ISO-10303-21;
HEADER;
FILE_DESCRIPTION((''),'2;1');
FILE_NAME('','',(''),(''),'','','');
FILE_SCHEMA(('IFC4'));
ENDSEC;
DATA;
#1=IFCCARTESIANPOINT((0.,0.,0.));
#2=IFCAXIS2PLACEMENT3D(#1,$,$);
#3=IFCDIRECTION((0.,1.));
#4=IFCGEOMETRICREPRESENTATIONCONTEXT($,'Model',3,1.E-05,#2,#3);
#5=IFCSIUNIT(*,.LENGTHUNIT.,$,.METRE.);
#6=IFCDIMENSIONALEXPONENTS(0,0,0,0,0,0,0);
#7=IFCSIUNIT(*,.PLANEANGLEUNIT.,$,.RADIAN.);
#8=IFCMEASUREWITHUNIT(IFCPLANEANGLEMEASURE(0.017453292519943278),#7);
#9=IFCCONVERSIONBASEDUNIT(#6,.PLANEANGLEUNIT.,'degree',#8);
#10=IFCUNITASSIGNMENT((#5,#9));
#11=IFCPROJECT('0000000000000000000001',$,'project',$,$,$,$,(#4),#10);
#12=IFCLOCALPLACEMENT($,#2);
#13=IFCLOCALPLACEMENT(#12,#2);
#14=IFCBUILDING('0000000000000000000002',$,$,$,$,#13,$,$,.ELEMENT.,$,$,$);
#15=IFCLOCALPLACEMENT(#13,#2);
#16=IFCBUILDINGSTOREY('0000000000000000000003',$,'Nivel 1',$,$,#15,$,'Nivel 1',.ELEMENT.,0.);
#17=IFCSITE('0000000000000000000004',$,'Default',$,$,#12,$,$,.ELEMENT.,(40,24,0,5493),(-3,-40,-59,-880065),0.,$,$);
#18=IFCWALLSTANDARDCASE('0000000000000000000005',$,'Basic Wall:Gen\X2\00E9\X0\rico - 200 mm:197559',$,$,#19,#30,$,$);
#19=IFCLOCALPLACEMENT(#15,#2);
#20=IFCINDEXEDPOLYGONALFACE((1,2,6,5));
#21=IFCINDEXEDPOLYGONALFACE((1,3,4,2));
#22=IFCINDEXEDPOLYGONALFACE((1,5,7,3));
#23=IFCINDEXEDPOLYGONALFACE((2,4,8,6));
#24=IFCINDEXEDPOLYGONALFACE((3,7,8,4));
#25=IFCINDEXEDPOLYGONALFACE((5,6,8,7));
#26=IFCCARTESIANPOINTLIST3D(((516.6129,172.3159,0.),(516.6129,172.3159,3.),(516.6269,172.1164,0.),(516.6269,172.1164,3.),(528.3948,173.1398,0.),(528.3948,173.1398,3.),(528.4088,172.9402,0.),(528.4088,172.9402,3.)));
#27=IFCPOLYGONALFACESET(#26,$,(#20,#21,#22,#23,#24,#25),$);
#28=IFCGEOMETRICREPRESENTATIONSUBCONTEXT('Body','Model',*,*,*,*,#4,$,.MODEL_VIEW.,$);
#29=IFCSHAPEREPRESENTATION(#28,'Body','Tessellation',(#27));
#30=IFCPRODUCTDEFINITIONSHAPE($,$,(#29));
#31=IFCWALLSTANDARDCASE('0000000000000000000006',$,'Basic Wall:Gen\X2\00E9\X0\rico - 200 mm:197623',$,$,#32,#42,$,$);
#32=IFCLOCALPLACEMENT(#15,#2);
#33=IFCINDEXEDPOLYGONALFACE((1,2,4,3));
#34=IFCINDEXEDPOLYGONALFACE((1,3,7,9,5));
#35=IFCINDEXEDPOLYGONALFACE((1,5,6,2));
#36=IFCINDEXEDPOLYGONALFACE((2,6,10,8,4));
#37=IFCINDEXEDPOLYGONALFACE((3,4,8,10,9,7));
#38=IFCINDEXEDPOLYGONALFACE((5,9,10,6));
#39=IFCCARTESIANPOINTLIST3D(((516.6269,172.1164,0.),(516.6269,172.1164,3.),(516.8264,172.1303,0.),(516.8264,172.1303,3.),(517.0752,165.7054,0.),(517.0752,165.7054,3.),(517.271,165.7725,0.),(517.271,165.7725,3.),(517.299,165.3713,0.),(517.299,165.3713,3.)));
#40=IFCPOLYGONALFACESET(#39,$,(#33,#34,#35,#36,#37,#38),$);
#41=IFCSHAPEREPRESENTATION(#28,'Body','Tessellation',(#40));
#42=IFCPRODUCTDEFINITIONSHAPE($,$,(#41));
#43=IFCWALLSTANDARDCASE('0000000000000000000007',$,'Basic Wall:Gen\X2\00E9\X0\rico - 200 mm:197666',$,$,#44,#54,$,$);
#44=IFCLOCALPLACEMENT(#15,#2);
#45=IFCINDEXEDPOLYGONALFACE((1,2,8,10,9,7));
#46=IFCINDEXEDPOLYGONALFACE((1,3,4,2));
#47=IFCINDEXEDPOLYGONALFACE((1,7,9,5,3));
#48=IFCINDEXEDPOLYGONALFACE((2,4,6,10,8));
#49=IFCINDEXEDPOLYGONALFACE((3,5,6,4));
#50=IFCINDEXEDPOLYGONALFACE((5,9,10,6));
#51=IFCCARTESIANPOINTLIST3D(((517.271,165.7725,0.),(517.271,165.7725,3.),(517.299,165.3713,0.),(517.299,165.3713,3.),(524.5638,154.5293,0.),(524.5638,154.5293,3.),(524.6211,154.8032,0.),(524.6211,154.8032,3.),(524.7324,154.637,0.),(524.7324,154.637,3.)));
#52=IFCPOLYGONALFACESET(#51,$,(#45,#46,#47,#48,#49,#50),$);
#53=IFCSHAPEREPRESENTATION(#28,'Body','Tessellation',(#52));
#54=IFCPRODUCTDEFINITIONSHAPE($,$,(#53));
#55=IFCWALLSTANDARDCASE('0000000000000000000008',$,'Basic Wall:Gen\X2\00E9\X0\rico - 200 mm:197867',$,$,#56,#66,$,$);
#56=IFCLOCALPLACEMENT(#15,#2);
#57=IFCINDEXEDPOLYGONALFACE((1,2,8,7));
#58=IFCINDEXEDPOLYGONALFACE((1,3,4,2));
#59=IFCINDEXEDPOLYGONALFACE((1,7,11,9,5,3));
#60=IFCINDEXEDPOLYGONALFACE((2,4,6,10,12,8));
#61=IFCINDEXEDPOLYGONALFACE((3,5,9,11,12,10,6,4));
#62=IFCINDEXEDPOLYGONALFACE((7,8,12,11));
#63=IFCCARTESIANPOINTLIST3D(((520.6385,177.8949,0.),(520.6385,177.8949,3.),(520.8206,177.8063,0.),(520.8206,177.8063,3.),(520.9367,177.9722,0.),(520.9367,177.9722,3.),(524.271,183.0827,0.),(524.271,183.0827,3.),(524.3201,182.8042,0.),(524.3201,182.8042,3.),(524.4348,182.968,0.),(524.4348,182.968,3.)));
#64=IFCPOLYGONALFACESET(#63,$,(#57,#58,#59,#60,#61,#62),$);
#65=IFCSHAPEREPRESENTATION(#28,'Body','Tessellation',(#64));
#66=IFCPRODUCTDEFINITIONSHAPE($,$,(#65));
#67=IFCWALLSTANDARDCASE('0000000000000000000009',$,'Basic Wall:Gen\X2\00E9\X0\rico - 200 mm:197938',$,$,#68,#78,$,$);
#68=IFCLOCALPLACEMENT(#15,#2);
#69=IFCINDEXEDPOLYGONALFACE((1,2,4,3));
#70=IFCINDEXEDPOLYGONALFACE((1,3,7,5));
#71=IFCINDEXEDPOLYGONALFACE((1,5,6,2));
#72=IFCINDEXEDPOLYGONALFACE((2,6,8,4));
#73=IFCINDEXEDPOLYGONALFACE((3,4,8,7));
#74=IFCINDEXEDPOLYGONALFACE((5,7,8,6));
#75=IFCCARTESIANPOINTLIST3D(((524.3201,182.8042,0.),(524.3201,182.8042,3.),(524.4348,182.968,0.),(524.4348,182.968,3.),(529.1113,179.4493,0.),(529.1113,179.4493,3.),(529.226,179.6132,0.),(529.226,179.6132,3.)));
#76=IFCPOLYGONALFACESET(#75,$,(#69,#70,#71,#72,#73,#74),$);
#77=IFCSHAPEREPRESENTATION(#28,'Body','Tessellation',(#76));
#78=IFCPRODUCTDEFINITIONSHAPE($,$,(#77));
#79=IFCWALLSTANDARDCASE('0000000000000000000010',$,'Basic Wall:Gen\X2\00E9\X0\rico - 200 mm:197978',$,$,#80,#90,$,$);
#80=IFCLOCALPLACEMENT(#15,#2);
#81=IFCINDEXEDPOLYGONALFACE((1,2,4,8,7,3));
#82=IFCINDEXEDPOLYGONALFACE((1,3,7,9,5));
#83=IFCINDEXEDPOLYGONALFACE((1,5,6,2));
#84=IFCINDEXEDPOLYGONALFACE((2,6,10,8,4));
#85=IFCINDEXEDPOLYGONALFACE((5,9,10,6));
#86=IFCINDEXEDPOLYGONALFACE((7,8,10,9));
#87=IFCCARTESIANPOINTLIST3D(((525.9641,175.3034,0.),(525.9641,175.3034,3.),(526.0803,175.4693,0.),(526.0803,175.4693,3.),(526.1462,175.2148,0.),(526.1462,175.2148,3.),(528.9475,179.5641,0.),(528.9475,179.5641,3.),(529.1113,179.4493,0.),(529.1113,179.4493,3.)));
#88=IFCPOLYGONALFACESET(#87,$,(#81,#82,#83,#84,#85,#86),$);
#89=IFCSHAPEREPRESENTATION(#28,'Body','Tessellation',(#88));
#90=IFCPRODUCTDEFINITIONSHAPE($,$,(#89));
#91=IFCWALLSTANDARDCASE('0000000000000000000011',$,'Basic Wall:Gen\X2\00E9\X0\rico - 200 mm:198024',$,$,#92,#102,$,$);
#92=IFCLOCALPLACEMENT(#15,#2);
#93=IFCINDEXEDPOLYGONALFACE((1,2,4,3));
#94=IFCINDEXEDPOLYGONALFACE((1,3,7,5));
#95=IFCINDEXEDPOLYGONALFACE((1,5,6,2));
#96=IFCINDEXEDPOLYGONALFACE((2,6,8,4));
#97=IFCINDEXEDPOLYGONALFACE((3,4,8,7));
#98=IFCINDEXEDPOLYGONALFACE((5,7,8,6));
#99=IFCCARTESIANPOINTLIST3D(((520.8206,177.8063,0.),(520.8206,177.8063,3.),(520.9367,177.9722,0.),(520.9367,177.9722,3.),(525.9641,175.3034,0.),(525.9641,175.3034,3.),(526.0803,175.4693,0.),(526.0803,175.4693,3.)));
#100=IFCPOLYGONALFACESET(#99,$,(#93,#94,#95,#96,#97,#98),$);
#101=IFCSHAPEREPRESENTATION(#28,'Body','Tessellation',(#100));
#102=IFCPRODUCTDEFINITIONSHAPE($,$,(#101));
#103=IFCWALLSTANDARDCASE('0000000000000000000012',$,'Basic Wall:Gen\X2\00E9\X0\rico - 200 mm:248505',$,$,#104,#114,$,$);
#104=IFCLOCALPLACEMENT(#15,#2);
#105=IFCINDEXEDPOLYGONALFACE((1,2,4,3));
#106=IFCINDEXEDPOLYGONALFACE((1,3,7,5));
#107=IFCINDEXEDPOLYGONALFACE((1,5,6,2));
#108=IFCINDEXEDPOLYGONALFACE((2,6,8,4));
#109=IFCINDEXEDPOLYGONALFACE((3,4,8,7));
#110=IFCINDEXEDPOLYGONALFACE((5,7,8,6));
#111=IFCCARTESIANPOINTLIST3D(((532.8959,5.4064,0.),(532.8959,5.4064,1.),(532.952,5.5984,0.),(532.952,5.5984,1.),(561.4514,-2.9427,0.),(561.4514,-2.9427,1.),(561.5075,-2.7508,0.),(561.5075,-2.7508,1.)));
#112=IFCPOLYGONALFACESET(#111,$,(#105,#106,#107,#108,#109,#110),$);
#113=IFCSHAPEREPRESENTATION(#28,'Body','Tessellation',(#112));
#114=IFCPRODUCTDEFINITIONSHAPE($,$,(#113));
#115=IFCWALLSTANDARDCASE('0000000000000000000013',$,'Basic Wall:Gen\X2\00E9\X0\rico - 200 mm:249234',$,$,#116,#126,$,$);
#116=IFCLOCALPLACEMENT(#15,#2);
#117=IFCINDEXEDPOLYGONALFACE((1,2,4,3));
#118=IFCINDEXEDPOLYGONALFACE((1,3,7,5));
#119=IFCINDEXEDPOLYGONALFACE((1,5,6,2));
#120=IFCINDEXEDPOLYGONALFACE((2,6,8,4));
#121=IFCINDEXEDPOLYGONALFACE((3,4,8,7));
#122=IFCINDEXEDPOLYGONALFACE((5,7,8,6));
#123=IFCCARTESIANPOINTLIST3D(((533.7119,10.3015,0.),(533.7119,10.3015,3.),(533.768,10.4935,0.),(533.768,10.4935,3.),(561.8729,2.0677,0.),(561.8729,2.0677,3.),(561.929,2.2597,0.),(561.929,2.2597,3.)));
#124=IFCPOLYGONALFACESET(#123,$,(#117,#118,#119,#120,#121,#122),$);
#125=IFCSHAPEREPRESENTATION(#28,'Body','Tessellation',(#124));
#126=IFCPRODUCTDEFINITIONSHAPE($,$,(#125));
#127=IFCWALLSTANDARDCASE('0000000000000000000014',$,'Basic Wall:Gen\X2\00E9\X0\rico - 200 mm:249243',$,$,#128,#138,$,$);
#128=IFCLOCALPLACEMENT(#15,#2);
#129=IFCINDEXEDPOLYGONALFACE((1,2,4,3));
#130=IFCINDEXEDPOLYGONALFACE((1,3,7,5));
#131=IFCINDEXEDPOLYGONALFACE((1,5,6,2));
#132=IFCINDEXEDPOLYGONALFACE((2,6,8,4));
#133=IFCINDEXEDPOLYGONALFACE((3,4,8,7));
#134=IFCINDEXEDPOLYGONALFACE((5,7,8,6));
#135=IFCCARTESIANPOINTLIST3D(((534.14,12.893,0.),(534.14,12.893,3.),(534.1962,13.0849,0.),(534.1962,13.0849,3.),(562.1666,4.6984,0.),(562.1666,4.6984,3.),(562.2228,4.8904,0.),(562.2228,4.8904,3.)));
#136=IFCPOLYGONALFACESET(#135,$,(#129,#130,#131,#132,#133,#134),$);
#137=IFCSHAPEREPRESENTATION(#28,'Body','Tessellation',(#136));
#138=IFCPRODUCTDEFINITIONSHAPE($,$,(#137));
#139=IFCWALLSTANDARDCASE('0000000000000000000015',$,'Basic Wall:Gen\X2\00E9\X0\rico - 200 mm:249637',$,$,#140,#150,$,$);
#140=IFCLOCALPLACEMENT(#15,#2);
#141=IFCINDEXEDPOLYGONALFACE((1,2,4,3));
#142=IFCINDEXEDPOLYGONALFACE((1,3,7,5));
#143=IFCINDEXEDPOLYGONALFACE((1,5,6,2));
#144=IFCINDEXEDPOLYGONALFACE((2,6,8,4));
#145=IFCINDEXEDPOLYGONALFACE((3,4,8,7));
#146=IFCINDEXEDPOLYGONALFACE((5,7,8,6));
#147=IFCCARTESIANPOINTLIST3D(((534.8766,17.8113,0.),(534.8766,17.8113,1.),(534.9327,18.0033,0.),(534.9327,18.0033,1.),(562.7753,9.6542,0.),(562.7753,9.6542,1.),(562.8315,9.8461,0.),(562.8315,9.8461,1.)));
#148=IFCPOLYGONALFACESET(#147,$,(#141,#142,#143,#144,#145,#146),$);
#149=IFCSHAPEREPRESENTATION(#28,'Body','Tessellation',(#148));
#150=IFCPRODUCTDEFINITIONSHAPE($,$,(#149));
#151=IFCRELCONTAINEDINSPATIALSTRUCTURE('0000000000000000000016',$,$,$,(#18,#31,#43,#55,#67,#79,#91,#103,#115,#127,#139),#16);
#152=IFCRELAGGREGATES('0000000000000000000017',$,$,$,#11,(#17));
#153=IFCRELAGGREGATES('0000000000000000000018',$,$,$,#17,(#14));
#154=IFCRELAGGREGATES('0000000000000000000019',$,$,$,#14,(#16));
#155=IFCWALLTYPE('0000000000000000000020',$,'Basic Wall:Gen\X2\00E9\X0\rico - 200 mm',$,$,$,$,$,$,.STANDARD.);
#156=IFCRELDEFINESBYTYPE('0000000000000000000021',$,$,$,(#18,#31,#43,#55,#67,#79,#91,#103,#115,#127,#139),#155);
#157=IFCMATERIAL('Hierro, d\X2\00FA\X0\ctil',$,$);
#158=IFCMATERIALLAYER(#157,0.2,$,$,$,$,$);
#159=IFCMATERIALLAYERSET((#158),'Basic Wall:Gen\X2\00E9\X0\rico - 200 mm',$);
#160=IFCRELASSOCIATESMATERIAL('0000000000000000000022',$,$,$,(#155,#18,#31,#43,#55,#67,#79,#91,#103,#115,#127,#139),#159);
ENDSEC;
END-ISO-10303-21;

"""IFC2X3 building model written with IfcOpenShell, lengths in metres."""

from ifc_helpers import new_model, entity, si_unit, converted_unit, direction, frame, frame_2d, origin, place, context, subcontext, project, spatial, polyline, rectangle, outline, extrude, material, layer, layer_set, layer_usage, type_object, element, save


model = new_model("IFC2X3")

# Units and contexts
model_context = context("Model", 3, precision=1e-05, world=origin(), true_north=direction((0.0, 1.0)))
body_context = subcontext(model_context, "Body", "Model", "MODEL_VIEW")
ifc_project = project(units=[si_unit("LENGTHUNIT", "METRE"), converted_unit("PLANEANGLEUNIT", "degree", entity("IfcPlaneAngleMeasure", 0.017453292519943278), si_unit("PLANEANGLEUNIT", "RADIAN"), dimensions=[0, 0, 0, 0, 0, 0, 0])], contexts=[model_context])

# Site, building, storey
site_placement = place(None, origin())
site = spatial("IfcSite", under=ifc_project, at=site_placement, Name="Default", CompositionType="ELEMENT", RefLatitude=(40, 24, 0, 5493), RefLongitude=(-3, -40, -59, -880065), RefElevation=0.0)
building_placement = place(site_placement, origin())
building = spatial("IfcBuilding", under=site, at=building_placement, CompositionType="ELEMENT")
storey_placement = place(building_placement, origin())
storey = spatial("IfcBuildingStorey", under=building, at=storey_placement, Name="Nivel 1", LongName="Nivel 1", CompositionType="ELEMENT", Elevation=0.0)

# Walls
ifc_material_1 = material(Name="Hierro, dúctil")
ifc_layer_1 = layer(ifc_material_1, 0.2)
ifc_layer_set_1 = layer_set([ifc_layer_1], Name="Basic Wall:Genérico - 200 mm")
wall_type = type_object("IfcWallType", Name="Basic Wall:Genérico - 200 mm", PredefinedType="STANDARD", material=ifc_layer_set_1)
ifc_layer_usage_1 = layer_usage(ifc_layer_set_1, "AXIS2", "NEGATIVE", 0.1)
wall_1_placement = place(storey_placement, frame((528.4018, 173.04, 0.0), z_axis=(0.0, 0.0, 1.0), x_axis=(-0.997564, -0.069756, 0.0)))
element("IfcWallStandardCase", 1, at=wall_1_placement, inside=storey, type_object=wall_type, material=ifc_layer_usage_1, Name="Basic Wall:Genérico - 200 mm:197559", context=body_context, shape_type="SweptSolid", body=[
    extrude(rectangle(XDim=11.8107, YDim=0.2, at=frame_2d((5.9053, 0.0), x_axis=(-1.0, 0.0))), origin(), (0.0, 0.0, 1.0), 3.0),
])
ifc_layer_usage_2 = layer_usage(ifc_layer_set_1, "AXIS2", "NEGATIVE", 0.1)
wall_2_placement = place(storey_placement, frame((516.7266, 172.1233, 0.0), z_axis=(0.0, 0.0, 1.0), x_axis=(0.069756, -0.997564, 0.0)))
element("IfcWallStandardCase", 2, at=wall_2_placement, inside=storey, type_object=wall_type, material=ifc_layer_usage_2, Name="Basic Wall:Genérico - 200 mm:197623", context=body_context, shape_type="SweptSolid", body=[
    extrude(outline(polyline([(6.4266, -0.1), (6.7755, 0.1), (6.3734, 0.1), (0.0, 0.1), (0.0, -0.1), (6.4266, -0.1)])), origin(), (0.0, 0.0, 1.0), 3.0),
])
ifc_layer_usage_3 = layer_usage(ifc_layer_set_1, "AXIS2", "NEGATIVE", 0.1)
wall_3_placement = place(storey_placement, frame((517.1879, 165.7168, 0.0), z_axis=(0.0, 0.0, 1.0), x_axis=(0.556652, -0.830746, 0.0)))
element("IfcWallStandardCase", 3, at=wall_3_placement, inside=storey, type_object=wall_type, material=ifc_layer_usage_3, Name="Basic Wall:Genérico - 200 mm:197666", context=body_context, shape_type="SweptSolid", body=[
    extrude(outline(polyline([(13.3998, -0.1), (13.4042, 0.1), (13.2041, 0.1), (0.0, 0.1), (0.3489, -0.1), (13.3998, -0.1)])), origin(), (0.0, 0.0, 1.0), 3.0),
])
ifc_layer_usage_4 = layer_usage(ifc_layer_set_1, "AXIS2", "NEGATIVE", 0.1)
wall_4_placement = place(storey_placement, frame((520.7204, 177.8376, 0.0), z_axis=(0.0, 0.0, 1.0), x_axis=(0.573576, 0.819152, 0.0)))
element("IfcWallStandardCase", 4, at=wall_4_placement, inside=storey, type_object=wall_type, material=ifc_layer_usage_4, Name="Basic Wall:Genérico - 200 mm:197867", context=body_context, shape_type="SweptSolid", body=[
    extrude(outline(polyline([(6.3331, -0.1), (6.3331, 0.1), (0.0, 0.1), (0.0319, -0.1), (0.2344, -0.1), (6.1331, -0.1), (6.3331, -0.1)])), origin(), (0.0, 0.0, 1.0), 3.0),
])
ifc_layer_usage_5 = layer_usage(ifc_layer_set_1, "AXIS2", "NEGATIVE", 0.1)
wall_5_placement = place(storey_placement, frame((524.3775, 182.8861, 0.0), z_axis=(0.0, 0.0, 1.0), x_axis=(0.819152, -0.573576, 0.0)))
element("IfcWallStandardCase", 5, at=wall_5_placement, inside=storey, type_object=wall_type, material=ifc_layer_usage_5, Name="Basic Wall:Genérico - 200 mm:197938", context=body_context, shape_type="SweptSolid", body=[
    extrude(rectangle(XDim=5.849, YDim=0.2, at=frame_2d((2.9245, 0.0), x_axis=(-1.0, 0.0))), origin(), (0.0, 0.0, 1.0), 3.0),
])
ifc_layer_usage_6 = layer_usage(ifc_layer_set_1, "AXIS2", "NEGATIVE", 0.1)
wall_6_placement = place(storey_placement, frame((529.0294, 179.5067, 0.0), z_axis=(0.0, 0.0, 1.0), x_axis=(-0.573576, -0.819152, 0.0)))
element("IfcWallStandardCase", 6, at=wall_6_placement, inside=storey, type_object=wall_type, material=ifc_layer_usage_6, Name="Basic Wall:Genérico - 200 mm:197978", context=body_context, shape_type="SweptSolid", body=[
    extrude(outline(polyline([(5.2013, -0.1), (5.1694, 0.1), (0.0, 0.1), (0.0, -0.1), (4.9988, -0.1), (5.2013, -0.1)])), origin(), (0.0, 0.0, 1.0), 3.0),
])
ifc_layer_usage_7 = layer_usage(ifc_layer_set_1, "AXIS2", "NEGATIVE", 0.1)
wall_7_placement = place(storey_placement, frame((526.0365, 175.3794, 0.0), z_axis=(0.0, 0.0, 1.0), x_axis=(-0.899191, 0.437557, 0.0)))
element("IfcWallStandardCase", 7, at=wall_7_placement, inside=storey, type_object=wall_type, material=ifc_layer_usage_7, Name="Basic Wall:Genérico - 200 mm:198024", context=body_context, shape_type="SweptSolid", body=[
    extrude(outline(polyline([(5.7202, -0.1), (5.7521, 0.1), (0.0319, 0.1), (0.0, -0.1), (5.7202, -0.1)])), origin(), (0.0, 0.0, 1.0), 3.0),
])
ifc_layer_usage_8 = layer_usage(ifc_layer_set_1, "AXIS2", "NEGATIVE", 0.1)
wall_8_placement = place(storey_placement, frame((561.4794, -2.8468, 0.0), z_axis=(0.0, 0.0, 1.0), x_axis=(-0.959815, 0.280635, 0.0)))
element("IfcWallStandardCase", 8, at=wall_8_placement, inside=storey, type_object=wall_type, material=ifc_layer_usage_8, Name="Basic Wall:Genérico - 200 mm:248505", context=body_context, shape_type="SweptSolid", body=[
    extrude(rectangle(XDim=29.751, YDim=0.2, at=frame_2d((14.8755, 0.0), x_axis=(-1.0, 0.0))), origin(), (0.0, 0.0, 1.0), 1.0),
])
ifc_layer_usage_9 = layer_usage(ifc_layer_set_1, "AXIS2", "NEGATIVE", 0.1)
wall_9_placement = place(storey_placement, frame((561.9009, 2.1637, 0.0), z_axis=(0.0, 0.0, 1.0), x_axis=(-0.959815, 0.280635, 0.0)))
element("IfcWallStandardCase", 9, at=wall_9_placement, inside=storey, type_object=wall_type, material=ifc_layer_usage_9, Name="Basic Wall:Genérico - 200 mm:249234", context=body_context, shape_type="SweptSolid", body=[
    extrude(rectangle(XDim=29.34, YDim=0.2, at=frame_2d((14.67, 0.0), x_axis=(-1.0, 0.0))), origin(), (0.0, 0.0, 1.0), 3.0),
])
ifc_layer_usage_10 = layer_usage(ifc_layer_set_1, "AXIS2", "NEGATIVE", 0.1)
wall_10_placement = place(storey_placement, frame((562.1947, 4.7944, 0.0), z_axis=(0.0, 0.0, 1.0), x_axis=(-0.959815, 0.280635, 0.0)))
element("IfcWallStandardCase", 10, at=wall_10_placement, inside=storey, type_object=wall_type, material=ifc_layer_usage_10, Name="Basic Wall:Genérico - 200 mm:249243", context=body_context, shape_type="SweptSolid", body=[
    extrude(rectangle(XDim=29.2, YDim=0.2, at=frame_2d((14.6, 0.0), x_axis=(-1.0, 0.0))), origin(), (0.0, 0.0, 1.0), 3.0),
])
ifc_layer_usage_11 = layer_usage(ifc_layer_set_1, "AXIS2", "NEGATIVE", 0.1)
wall_11_placement = place(storey_placement, frame((562.8034, 9.7502, 0.0), z_axis=(0.0, 0.0, 1.0), x_axis=(-0.959815, 0.280635, 0.0)))
element("IfcWallStandardCase", 11, at=wall_11_placement, inside=storey, type_object=wall_type, material=ifc_layer_usage_11, Name="Basic Wall:Genérico - 200 mm:249637", context=body_context, shape_type="SweptSolid", body=[
    extrude(rectangle(XDim=29.0668, YDim=0.2, at=frame_2d((14.5334, 0.0), x_axis=(-1.0, 0.0))), origin(), (0.0, 0.0, 1.0), 1.0),
])

save(model, "model.ifc")
